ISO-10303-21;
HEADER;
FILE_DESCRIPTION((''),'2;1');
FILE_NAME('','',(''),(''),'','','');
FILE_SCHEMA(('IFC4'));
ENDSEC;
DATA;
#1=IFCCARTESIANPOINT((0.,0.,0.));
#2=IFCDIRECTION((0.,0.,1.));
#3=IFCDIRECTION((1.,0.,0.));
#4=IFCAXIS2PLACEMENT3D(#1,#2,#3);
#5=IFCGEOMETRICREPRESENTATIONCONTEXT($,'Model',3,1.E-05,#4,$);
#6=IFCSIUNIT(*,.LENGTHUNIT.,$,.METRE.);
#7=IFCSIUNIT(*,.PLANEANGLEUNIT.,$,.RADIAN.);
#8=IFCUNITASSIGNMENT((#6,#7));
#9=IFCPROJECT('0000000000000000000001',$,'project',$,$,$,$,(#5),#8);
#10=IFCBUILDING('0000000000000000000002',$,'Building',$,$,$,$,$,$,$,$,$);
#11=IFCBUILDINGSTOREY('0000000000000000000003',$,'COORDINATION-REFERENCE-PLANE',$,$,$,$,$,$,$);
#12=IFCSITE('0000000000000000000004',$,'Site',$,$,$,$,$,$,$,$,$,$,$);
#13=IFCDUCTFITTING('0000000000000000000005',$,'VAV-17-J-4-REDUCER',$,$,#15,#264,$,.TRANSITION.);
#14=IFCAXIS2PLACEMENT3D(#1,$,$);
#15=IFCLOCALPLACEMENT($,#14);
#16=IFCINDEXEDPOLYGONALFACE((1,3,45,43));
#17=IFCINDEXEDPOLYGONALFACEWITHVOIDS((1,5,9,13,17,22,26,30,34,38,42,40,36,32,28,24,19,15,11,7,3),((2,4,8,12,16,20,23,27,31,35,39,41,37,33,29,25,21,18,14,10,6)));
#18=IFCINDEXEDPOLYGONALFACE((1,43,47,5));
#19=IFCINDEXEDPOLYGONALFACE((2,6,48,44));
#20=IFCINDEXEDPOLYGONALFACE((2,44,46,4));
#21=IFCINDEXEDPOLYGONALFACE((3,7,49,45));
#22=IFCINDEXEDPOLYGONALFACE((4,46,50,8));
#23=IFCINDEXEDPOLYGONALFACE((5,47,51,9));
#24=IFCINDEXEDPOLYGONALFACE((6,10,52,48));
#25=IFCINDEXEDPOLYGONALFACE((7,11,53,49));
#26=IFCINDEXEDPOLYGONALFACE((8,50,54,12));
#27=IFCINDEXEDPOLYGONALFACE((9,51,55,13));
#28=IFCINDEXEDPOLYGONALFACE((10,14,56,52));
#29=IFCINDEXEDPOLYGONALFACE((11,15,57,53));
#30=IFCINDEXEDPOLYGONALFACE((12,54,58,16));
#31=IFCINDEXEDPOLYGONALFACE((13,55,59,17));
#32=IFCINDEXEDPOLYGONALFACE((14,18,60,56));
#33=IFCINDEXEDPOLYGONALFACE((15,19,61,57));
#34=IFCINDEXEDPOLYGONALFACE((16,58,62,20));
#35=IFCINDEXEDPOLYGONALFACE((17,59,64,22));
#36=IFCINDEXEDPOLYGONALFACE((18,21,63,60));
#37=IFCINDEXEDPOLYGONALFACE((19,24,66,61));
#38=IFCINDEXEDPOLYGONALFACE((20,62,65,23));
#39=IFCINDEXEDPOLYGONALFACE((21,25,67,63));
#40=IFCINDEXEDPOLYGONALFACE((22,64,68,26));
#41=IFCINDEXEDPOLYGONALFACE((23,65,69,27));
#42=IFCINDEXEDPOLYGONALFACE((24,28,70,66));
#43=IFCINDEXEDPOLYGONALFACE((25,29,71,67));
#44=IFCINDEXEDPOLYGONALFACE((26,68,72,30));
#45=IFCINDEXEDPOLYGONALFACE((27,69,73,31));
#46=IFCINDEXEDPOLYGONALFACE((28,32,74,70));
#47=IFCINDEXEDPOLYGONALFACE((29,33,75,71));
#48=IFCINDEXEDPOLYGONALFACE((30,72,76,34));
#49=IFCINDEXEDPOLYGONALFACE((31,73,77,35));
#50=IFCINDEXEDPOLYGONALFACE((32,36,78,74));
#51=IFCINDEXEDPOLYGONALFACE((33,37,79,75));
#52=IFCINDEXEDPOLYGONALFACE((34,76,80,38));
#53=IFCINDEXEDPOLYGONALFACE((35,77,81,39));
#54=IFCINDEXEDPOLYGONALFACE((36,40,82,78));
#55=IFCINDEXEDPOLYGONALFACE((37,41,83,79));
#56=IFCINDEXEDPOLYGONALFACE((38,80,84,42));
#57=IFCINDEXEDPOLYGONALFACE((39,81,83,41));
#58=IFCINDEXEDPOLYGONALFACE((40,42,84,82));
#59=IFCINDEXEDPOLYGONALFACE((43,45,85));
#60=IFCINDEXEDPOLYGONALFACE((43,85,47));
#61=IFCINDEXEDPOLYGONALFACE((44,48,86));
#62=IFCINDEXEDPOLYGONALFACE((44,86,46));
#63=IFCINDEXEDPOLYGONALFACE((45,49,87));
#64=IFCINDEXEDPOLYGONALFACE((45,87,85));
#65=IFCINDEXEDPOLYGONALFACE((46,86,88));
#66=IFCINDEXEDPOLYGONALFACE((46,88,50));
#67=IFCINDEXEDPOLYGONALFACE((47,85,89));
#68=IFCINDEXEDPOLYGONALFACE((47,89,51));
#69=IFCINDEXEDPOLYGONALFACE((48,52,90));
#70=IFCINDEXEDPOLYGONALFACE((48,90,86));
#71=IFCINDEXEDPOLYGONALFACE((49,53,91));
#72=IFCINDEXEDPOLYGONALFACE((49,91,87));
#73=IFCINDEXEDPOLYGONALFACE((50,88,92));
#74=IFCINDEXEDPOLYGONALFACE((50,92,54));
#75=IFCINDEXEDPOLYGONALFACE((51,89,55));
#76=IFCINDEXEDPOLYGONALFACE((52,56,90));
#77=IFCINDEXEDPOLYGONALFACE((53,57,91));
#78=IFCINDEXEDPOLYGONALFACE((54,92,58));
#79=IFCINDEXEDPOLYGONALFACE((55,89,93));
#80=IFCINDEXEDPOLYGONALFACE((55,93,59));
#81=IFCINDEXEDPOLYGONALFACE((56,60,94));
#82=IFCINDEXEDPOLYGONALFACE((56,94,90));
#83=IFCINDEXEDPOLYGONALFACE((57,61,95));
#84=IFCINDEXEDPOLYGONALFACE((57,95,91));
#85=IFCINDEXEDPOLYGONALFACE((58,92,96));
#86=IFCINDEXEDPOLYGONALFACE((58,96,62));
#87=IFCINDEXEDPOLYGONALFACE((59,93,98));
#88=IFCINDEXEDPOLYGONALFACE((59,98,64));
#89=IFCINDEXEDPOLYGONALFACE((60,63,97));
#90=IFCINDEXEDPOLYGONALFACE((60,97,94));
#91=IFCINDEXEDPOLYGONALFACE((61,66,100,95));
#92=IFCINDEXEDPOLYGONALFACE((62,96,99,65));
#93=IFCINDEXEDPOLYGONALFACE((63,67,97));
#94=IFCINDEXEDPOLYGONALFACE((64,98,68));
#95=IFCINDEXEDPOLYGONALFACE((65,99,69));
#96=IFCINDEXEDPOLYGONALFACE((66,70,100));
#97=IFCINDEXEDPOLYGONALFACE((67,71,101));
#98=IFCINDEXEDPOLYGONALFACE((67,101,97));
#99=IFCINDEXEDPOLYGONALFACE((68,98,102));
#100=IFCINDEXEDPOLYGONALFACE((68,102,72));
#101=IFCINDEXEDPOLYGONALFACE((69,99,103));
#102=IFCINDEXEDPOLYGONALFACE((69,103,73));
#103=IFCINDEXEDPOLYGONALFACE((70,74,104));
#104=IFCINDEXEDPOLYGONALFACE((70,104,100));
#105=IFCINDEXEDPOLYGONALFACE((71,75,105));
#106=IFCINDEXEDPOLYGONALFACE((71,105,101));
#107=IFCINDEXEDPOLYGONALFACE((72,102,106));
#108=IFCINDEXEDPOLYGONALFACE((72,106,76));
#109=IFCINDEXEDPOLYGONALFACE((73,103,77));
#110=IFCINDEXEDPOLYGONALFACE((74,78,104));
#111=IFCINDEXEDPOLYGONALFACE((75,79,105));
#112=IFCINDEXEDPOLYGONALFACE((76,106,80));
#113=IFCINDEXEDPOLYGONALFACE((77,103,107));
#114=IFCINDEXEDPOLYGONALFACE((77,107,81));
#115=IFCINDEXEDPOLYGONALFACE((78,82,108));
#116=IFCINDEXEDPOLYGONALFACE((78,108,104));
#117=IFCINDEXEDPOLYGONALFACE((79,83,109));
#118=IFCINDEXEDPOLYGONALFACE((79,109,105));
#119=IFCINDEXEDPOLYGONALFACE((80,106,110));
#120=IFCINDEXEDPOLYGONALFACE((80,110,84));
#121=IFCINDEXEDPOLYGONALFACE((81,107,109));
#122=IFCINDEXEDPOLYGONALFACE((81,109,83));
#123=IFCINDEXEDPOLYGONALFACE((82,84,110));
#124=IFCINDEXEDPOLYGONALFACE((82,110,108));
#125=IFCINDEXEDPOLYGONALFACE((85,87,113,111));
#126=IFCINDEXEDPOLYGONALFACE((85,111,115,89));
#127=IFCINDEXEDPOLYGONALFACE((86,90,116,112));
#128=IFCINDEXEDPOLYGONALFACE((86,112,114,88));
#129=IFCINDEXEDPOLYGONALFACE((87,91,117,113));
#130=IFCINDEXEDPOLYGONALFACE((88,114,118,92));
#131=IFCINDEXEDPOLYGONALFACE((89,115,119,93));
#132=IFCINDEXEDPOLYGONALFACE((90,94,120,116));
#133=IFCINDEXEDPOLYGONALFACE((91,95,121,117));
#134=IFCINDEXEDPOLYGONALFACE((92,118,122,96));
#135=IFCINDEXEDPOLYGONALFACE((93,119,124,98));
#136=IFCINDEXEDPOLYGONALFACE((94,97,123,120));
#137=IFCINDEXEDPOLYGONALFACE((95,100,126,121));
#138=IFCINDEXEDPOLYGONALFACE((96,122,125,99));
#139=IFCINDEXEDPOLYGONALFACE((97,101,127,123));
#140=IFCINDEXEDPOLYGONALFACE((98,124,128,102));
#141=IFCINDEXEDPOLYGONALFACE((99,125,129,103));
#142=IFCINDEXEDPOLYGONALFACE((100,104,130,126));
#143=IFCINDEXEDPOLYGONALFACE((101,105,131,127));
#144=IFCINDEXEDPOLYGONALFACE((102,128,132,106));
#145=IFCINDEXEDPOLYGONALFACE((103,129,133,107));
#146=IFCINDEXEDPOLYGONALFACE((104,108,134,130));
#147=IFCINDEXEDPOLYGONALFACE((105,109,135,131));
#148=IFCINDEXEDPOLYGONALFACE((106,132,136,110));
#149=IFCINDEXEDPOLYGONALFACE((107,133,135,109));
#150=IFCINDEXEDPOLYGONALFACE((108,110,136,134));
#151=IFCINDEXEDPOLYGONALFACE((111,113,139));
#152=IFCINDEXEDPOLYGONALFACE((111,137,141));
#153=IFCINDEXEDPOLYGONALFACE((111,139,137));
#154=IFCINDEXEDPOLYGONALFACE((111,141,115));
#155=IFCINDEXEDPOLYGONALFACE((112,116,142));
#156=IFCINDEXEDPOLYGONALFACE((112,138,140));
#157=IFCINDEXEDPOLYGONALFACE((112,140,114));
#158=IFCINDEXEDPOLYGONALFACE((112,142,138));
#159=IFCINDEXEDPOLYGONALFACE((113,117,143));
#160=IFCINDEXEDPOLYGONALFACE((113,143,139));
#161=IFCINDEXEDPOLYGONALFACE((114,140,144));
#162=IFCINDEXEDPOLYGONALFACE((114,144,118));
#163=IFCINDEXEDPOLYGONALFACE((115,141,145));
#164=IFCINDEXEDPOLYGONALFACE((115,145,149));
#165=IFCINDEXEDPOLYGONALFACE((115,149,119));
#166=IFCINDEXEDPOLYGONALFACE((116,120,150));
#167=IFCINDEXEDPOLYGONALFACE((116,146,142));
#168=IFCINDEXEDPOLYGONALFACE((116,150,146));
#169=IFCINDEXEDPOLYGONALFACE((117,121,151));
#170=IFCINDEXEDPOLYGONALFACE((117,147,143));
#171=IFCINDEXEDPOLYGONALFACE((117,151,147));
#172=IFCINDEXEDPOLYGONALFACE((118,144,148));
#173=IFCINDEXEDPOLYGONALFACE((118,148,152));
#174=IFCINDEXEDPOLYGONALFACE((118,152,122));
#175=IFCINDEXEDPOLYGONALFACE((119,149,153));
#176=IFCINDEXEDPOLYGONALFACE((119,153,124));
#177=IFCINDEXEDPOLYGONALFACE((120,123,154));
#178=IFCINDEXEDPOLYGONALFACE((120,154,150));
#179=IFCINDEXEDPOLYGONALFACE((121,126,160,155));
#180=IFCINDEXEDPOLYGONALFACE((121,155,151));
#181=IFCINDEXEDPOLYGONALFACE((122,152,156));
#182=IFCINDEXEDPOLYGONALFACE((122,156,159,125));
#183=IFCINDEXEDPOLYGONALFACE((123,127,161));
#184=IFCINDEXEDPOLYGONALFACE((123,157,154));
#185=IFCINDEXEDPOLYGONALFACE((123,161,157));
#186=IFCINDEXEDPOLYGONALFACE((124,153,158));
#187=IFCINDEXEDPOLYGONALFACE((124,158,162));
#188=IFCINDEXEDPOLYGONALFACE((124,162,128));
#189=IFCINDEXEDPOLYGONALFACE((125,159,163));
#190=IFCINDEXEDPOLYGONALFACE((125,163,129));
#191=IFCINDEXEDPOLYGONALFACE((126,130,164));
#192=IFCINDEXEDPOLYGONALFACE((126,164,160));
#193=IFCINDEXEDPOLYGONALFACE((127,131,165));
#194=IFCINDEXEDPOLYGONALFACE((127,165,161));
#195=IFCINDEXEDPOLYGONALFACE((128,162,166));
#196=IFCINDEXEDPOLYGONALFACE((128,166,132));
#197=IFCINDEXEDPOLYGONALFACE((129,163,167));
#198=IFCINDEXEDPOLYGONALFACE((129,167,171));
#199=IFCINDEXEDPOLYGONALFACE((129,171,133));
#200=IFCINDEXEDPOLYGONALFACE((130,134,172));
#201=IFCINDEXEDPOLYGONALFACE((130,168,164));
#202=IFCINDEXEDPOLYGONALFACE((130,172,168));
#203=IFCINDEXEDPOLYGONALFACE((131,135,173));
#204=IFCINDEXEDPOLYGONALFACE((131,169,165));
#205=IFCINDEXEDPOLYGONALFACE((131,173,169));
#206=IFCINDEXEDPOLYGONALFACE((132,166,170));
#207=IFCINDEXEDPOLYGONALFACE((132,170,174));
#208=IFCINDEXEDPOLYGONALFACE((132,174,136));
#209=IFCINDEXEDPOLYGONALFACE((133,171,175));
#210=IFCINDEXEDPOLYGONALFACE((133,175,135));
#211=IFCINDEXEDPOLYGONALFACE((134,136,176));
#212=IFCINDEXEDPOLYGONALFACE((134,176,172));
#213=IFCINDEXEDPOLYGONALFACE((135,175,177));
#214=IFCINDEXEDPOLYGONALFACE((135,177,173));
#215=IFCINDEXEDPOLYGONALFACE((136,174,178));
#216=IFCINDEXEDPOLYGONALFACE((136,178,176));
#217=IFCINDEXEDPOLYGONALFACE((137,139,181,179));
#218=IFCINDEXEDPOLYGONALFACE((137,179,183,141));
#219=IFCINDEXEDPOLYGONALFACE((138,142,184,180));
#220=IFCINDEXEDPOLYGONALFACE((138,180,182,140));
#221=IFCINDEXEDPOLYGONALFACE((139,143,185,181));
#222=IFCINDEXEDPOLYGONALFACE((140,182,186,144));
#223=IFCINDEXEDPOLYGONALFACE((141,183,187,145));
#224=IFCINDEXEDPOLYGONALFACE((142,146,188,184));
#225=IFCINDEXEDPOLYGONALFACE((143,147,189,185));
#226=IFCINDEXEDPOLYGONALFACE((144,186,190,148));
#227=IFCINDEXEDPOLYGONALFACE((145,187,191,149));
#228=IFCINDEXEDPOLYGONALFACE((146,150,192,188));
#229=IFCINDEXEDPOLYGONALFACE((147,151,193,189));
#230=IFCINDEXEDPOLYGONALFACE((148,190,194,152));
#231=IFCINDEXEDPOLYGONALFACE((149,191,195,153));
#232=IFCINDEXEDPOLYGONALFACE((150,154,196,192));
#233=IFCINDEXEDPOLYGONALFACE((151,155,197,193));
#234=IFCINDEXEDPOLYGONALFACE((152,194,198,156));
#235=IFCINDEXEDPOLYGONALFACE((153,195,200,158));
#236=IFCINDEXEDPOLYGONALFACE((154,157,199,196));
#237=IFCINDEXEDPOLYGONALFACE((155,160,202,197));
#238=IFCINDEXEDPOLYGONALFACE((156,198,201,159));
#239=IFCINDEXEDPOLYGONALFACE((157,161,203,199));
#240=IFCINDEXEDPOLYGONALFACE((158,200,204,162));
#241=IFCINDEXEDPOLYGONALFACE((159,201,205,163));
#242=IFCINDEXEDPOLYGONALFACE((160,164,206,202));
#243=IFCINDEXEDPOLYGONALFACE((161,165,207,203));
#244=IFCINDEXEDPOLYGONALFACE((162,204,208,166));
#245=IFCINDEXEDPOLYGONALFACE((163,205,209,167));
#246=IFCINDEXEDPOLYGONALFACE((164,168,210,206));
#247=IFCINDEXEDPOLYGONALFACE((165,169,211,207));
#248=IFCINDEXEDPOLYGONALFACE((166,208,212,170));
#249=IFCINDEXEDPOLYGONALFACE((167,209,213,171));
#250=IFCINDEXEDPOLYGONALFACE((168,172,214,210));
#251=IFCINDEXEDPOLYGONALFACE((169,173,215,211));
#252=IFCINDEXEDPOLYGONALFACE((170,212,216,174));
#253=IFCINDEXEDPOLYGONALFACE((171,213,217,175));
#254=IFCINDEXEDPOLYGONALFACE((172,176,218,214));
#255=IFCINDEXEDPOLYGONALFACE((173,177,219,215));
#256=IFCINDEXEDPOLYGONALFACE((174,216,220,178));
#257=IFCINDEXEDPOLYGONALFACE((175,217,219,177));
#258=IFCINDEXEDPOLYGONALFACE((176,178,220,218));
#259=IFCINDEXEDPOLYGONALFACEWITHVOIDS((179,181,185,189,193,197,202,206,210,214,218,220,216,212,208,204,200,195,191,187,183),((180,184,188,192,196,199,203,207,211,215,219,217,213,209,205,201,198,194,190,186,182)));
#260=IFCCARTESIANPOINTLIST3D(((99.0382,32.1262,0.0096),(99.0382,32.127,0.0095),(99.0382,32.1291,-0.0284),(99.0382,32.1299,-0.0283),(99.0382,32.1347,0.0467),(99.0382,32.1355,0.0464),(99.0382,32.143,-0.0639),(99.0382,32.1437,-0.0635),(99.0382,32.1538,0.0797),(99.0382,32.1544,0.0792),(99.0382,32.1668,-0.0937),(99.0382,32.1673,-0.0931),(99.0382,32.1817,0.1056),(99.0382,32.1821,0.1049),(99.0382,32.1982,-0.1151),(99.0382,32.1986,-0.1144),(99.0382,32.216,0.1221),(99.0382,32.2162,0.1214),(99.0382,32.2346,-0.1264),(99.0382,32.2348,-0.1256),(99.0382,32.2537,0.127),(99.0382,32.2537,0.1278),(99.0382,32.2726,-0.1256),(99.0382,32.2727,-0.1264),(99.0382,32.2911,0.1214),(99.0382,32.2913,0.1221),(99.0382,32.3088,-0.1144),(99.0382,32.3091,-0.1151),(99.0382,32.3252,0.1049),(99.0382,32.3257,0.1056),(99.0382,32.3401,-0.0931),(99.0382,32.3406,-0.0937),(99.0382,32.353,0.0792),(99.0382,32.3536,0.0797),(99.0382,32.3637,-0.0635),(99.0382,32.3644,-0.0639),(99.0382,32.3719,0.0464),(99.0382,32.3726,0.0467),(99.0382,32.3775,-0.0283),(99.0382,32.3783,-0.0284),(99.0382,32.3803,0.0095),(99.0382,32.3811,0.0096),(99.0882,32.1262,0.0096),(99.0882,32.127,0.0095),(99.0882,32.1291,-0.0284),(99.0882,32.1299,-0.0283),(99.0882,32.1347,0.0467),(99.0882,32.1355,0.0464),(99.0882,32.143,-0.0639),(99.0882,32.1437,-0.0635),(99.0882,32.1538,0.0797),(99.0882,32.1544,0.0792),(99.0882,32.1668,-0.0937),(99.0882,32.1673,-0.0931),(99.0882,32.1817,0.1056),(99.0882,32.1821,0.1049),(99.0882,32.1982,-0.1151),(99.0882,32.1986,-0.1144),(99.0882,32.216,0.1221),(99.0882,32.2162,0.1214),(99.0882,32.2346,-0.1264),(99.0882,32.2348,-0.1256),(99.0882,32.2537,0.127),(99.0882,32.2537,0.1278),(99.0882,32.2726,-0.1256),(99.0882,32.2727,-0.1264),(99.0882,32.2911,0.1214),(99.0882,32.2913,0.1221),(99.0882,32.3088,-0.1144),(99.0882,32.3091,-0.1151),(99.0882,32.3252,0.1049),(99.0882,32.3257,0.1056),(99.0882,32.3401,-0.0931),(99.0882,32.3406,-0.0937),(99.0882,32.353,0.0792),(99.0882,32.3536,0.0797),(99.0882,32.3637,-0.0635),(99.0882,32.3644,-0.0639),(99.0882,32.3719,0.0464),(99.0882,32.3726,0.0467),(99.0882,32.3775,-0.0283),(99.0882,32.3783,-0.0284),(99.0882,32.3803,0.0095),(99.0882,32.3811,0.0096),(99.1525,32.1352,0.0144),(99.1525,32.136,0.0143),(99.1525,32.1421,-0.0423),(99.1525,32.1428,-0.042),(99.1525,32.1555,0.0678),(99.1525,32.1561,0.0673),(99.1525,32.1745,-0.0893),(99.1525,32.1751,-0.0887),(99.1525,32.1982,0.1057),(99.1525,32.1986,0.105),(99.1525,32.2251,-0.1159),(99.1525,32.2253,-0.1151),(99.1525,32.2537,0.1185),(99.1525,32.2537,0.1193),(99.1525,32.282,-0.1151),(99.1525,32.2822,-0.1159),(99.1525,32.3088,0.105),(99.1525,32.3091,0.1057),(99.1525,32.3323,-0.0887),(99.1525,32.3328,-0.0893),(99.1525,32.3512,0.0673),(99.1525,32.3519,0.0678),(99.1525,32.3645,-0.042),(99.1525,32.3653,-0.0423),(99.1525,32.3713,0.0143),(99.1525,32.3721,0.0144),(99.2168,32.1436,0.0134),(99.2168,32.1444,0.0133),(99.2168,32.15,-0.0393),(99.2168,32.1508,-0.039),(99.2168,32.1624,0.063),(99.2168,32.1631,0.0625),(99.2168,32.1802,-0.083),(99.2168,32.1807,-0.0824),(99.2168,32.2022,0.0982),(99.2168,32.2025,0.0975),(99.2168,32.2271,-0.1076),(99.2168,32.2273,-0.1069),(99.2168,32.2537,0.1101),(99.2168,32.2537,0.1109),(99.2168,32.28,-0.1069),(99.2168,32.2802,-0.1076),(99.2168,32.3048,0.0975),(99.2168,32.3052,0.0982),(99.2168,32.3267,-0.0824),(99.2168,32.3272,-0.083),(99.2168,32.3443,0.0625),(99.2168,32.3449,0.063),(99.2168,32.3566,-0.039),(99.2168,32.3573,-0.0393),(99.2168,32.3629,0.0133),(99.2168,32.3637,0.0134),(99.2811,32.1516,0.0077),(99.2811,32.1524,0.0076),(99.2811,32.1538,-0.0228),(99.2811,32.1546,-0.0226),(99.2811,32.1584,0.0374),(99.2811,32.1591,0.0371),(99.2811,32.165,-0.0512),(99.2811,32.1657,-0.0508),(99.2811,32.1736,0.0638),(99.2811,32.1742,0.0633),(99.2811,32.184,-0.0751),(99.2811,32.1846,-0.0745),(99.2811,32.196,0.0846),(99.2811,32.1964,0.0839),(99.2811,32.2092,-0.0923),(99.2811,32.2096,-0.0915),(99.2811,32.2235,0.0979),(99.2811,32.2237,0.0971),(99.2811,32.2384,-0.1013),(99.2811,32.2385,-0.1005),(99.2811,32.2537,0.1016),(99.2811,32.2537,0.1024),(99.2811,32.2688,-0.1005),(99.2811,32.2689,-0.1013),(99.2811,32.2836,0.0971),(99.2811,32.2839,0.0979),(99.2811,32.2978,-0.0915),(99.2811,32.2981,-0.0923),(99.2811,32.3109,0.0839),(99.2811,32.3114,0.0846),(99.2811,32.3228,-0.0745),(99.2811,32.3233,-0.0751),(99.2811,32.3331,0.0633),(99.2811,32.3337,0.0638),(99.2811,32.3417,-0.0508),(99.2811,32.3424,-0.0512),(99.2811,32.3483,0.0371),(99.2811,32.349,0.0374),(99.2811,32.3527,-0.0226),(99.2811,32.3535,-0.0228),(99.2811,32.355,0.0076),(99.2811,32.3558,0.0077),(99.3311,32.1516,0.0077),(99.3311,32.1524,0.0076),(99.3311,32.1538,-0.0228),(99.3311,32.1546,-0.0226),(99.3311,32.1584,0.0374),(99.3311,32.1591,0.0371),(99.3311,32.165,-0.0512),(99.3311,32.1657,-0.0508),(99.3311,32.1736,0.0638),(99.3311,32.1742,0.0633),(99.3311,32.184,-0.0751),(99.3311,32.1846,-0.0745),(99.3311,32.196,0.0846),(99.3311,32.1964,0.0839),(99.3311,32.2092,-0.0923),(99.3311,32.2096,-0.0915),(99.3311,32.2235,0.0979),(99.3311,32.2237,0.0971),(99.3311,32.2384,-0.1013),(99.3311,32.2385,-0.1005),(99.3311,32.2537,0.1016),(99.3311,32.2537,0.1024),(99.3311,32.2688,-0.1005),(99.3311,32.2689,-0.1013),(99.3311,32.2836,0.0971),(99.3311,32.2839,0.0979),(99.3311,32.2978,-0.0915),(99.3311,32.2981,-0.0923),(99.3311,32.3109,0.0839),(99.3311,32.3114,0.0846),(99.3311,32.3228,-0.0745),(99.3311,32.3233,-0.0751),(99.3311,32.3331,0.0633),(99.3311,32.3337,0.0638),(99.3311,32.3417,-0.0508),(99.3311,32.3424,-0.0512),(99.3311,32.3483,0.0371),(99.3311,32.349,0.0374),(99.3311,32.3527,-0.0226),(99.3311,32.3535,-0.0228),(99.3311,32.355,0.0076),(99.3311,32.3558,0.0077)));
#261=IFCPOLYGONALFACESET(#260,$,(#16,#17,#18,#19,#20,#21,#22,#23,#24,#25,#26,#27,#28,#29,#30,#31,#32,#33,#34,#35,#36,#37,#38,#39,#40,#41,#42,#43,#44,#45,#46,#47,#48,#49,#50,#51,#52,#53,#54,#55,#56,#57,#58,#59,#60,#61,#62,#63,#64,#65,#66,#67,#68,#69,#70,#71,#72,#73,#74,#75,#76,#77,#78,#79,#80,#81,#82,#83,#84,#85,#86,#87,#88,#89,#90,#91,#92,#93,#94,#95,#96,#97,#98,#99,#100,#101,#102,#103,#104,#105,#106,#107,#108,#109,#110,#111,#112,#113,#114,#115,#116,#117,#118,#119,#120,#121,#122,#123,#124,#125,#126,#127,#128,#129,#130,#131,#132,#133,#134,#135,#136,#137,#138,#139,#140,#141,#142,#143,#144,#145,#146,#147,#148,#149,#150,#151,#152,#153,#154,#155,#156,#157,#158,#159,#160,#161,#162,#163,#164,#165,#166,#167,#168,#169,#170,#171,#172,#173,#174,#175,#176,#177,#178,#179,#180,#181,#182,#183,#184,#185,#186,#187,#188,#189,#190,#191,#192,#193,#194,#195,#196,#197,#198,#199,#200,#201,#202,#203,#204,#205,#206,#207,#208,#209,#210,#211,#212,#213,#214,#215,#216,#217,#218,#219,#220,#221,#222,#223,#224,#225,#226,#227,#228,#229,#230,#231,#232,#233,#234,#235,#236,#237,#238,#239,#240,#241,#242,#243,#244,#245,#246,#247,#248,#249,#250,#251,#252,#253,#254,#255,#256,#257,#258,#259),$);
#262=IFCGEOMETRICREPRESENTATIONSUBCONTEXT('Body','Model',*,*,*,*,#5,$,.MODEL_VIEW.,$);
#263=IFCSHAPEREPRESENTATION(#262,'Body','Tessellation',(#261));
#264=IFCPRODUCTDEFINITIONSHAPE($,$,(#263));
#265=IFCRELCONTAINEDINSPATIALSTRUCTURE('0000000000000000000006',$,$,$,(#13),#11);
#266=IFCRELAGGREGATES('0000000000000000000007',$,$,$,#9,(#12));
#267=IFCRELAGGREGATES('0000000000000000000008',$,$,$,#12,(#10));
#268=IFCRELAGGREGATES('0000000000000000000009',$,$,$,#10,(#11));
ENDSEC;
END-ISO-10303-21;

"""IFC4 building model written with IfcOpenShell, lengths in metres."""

from ifc_helpers import new_model, entity, si_unit, frame, origin_with_axes, place, context, subcontext, project, spatial, element, save


model = new_model("IFC4")

# Units and contexts
model_context = context("Model", 3, precision=1e-05, world=origin_with_axes())
body_context_1 = subcontext(model_context, "Body", "Model", "MODEL_VIEW")
ifc_project = project(units=[si_unit("LENGTHUNIT", "METRE"), si_unit("PLANEANGLEUNIT", "RADIAN")], contexts=[model_context])

# Site, building, storey
site = spatial("IfcSite", under=ifc_project, Name="Site")
building = spatial("IfcBuilding", under=site, Name="Building")
storey = spatial("IfcBuildingStorey", under=building, Name="COORDINATION-REFERENCE-PLANE")

# Duct fitting
for number, where, z_axis, x_axis, name in (
    (1, (99.0382, 32.2537, 0.0), (0.0, 1.0, 0.0), (0.0, 0.0, 1.0), "VAV-17-J-4-REDUCER"),
):
    element("IfcDuctFitting", number, at=place(None, frame(where, z_axis=z_axis, x_axis=x_axis)), inside=storey, Name=name, PredefinedType="TRANSITION", context=body_context_1, shape_type="SweptSolid", body=[
        entity("IfcRevolvedAreaSolid", entity("IfcArbitraryClosedProfileDef", "AREA", None, entity("IfcPolyline", [entity("IfcCartesianPoint", [0.1278, 0.0]), entity("IfcCartesianPoint", [0.1278, 0.05]), entity("IfcCartesianPoint", [0.1024, 0.2429]), entity("IfcCartesianPoint", [0.1024, 0.2929]), entity("IfcCartesianPoint", [0.1016, 0.2929]), entity("IfcCartesianPoint", [0.1016, 0.2429]), entity("IfcCartesianPoint", [0.127, 0.05]), entity("IfcCartesianPoint", [0.127, 0.0]), entity("IfcCartesianPoint", [0.1278, 0.0])])), entity("IfcAxis2Placement3D", entity("IfcCartesianPoint", [0.0, 0.0, 0.0])), entity("IfcAxis1Placement", entity("IfcCartesianPoint", [0.0, 0.0, 0.0]), entity("IfcDirection", [0.0, 1.0, 0.0])), 6.283185),
    ])

save(model, "model.ifc")
